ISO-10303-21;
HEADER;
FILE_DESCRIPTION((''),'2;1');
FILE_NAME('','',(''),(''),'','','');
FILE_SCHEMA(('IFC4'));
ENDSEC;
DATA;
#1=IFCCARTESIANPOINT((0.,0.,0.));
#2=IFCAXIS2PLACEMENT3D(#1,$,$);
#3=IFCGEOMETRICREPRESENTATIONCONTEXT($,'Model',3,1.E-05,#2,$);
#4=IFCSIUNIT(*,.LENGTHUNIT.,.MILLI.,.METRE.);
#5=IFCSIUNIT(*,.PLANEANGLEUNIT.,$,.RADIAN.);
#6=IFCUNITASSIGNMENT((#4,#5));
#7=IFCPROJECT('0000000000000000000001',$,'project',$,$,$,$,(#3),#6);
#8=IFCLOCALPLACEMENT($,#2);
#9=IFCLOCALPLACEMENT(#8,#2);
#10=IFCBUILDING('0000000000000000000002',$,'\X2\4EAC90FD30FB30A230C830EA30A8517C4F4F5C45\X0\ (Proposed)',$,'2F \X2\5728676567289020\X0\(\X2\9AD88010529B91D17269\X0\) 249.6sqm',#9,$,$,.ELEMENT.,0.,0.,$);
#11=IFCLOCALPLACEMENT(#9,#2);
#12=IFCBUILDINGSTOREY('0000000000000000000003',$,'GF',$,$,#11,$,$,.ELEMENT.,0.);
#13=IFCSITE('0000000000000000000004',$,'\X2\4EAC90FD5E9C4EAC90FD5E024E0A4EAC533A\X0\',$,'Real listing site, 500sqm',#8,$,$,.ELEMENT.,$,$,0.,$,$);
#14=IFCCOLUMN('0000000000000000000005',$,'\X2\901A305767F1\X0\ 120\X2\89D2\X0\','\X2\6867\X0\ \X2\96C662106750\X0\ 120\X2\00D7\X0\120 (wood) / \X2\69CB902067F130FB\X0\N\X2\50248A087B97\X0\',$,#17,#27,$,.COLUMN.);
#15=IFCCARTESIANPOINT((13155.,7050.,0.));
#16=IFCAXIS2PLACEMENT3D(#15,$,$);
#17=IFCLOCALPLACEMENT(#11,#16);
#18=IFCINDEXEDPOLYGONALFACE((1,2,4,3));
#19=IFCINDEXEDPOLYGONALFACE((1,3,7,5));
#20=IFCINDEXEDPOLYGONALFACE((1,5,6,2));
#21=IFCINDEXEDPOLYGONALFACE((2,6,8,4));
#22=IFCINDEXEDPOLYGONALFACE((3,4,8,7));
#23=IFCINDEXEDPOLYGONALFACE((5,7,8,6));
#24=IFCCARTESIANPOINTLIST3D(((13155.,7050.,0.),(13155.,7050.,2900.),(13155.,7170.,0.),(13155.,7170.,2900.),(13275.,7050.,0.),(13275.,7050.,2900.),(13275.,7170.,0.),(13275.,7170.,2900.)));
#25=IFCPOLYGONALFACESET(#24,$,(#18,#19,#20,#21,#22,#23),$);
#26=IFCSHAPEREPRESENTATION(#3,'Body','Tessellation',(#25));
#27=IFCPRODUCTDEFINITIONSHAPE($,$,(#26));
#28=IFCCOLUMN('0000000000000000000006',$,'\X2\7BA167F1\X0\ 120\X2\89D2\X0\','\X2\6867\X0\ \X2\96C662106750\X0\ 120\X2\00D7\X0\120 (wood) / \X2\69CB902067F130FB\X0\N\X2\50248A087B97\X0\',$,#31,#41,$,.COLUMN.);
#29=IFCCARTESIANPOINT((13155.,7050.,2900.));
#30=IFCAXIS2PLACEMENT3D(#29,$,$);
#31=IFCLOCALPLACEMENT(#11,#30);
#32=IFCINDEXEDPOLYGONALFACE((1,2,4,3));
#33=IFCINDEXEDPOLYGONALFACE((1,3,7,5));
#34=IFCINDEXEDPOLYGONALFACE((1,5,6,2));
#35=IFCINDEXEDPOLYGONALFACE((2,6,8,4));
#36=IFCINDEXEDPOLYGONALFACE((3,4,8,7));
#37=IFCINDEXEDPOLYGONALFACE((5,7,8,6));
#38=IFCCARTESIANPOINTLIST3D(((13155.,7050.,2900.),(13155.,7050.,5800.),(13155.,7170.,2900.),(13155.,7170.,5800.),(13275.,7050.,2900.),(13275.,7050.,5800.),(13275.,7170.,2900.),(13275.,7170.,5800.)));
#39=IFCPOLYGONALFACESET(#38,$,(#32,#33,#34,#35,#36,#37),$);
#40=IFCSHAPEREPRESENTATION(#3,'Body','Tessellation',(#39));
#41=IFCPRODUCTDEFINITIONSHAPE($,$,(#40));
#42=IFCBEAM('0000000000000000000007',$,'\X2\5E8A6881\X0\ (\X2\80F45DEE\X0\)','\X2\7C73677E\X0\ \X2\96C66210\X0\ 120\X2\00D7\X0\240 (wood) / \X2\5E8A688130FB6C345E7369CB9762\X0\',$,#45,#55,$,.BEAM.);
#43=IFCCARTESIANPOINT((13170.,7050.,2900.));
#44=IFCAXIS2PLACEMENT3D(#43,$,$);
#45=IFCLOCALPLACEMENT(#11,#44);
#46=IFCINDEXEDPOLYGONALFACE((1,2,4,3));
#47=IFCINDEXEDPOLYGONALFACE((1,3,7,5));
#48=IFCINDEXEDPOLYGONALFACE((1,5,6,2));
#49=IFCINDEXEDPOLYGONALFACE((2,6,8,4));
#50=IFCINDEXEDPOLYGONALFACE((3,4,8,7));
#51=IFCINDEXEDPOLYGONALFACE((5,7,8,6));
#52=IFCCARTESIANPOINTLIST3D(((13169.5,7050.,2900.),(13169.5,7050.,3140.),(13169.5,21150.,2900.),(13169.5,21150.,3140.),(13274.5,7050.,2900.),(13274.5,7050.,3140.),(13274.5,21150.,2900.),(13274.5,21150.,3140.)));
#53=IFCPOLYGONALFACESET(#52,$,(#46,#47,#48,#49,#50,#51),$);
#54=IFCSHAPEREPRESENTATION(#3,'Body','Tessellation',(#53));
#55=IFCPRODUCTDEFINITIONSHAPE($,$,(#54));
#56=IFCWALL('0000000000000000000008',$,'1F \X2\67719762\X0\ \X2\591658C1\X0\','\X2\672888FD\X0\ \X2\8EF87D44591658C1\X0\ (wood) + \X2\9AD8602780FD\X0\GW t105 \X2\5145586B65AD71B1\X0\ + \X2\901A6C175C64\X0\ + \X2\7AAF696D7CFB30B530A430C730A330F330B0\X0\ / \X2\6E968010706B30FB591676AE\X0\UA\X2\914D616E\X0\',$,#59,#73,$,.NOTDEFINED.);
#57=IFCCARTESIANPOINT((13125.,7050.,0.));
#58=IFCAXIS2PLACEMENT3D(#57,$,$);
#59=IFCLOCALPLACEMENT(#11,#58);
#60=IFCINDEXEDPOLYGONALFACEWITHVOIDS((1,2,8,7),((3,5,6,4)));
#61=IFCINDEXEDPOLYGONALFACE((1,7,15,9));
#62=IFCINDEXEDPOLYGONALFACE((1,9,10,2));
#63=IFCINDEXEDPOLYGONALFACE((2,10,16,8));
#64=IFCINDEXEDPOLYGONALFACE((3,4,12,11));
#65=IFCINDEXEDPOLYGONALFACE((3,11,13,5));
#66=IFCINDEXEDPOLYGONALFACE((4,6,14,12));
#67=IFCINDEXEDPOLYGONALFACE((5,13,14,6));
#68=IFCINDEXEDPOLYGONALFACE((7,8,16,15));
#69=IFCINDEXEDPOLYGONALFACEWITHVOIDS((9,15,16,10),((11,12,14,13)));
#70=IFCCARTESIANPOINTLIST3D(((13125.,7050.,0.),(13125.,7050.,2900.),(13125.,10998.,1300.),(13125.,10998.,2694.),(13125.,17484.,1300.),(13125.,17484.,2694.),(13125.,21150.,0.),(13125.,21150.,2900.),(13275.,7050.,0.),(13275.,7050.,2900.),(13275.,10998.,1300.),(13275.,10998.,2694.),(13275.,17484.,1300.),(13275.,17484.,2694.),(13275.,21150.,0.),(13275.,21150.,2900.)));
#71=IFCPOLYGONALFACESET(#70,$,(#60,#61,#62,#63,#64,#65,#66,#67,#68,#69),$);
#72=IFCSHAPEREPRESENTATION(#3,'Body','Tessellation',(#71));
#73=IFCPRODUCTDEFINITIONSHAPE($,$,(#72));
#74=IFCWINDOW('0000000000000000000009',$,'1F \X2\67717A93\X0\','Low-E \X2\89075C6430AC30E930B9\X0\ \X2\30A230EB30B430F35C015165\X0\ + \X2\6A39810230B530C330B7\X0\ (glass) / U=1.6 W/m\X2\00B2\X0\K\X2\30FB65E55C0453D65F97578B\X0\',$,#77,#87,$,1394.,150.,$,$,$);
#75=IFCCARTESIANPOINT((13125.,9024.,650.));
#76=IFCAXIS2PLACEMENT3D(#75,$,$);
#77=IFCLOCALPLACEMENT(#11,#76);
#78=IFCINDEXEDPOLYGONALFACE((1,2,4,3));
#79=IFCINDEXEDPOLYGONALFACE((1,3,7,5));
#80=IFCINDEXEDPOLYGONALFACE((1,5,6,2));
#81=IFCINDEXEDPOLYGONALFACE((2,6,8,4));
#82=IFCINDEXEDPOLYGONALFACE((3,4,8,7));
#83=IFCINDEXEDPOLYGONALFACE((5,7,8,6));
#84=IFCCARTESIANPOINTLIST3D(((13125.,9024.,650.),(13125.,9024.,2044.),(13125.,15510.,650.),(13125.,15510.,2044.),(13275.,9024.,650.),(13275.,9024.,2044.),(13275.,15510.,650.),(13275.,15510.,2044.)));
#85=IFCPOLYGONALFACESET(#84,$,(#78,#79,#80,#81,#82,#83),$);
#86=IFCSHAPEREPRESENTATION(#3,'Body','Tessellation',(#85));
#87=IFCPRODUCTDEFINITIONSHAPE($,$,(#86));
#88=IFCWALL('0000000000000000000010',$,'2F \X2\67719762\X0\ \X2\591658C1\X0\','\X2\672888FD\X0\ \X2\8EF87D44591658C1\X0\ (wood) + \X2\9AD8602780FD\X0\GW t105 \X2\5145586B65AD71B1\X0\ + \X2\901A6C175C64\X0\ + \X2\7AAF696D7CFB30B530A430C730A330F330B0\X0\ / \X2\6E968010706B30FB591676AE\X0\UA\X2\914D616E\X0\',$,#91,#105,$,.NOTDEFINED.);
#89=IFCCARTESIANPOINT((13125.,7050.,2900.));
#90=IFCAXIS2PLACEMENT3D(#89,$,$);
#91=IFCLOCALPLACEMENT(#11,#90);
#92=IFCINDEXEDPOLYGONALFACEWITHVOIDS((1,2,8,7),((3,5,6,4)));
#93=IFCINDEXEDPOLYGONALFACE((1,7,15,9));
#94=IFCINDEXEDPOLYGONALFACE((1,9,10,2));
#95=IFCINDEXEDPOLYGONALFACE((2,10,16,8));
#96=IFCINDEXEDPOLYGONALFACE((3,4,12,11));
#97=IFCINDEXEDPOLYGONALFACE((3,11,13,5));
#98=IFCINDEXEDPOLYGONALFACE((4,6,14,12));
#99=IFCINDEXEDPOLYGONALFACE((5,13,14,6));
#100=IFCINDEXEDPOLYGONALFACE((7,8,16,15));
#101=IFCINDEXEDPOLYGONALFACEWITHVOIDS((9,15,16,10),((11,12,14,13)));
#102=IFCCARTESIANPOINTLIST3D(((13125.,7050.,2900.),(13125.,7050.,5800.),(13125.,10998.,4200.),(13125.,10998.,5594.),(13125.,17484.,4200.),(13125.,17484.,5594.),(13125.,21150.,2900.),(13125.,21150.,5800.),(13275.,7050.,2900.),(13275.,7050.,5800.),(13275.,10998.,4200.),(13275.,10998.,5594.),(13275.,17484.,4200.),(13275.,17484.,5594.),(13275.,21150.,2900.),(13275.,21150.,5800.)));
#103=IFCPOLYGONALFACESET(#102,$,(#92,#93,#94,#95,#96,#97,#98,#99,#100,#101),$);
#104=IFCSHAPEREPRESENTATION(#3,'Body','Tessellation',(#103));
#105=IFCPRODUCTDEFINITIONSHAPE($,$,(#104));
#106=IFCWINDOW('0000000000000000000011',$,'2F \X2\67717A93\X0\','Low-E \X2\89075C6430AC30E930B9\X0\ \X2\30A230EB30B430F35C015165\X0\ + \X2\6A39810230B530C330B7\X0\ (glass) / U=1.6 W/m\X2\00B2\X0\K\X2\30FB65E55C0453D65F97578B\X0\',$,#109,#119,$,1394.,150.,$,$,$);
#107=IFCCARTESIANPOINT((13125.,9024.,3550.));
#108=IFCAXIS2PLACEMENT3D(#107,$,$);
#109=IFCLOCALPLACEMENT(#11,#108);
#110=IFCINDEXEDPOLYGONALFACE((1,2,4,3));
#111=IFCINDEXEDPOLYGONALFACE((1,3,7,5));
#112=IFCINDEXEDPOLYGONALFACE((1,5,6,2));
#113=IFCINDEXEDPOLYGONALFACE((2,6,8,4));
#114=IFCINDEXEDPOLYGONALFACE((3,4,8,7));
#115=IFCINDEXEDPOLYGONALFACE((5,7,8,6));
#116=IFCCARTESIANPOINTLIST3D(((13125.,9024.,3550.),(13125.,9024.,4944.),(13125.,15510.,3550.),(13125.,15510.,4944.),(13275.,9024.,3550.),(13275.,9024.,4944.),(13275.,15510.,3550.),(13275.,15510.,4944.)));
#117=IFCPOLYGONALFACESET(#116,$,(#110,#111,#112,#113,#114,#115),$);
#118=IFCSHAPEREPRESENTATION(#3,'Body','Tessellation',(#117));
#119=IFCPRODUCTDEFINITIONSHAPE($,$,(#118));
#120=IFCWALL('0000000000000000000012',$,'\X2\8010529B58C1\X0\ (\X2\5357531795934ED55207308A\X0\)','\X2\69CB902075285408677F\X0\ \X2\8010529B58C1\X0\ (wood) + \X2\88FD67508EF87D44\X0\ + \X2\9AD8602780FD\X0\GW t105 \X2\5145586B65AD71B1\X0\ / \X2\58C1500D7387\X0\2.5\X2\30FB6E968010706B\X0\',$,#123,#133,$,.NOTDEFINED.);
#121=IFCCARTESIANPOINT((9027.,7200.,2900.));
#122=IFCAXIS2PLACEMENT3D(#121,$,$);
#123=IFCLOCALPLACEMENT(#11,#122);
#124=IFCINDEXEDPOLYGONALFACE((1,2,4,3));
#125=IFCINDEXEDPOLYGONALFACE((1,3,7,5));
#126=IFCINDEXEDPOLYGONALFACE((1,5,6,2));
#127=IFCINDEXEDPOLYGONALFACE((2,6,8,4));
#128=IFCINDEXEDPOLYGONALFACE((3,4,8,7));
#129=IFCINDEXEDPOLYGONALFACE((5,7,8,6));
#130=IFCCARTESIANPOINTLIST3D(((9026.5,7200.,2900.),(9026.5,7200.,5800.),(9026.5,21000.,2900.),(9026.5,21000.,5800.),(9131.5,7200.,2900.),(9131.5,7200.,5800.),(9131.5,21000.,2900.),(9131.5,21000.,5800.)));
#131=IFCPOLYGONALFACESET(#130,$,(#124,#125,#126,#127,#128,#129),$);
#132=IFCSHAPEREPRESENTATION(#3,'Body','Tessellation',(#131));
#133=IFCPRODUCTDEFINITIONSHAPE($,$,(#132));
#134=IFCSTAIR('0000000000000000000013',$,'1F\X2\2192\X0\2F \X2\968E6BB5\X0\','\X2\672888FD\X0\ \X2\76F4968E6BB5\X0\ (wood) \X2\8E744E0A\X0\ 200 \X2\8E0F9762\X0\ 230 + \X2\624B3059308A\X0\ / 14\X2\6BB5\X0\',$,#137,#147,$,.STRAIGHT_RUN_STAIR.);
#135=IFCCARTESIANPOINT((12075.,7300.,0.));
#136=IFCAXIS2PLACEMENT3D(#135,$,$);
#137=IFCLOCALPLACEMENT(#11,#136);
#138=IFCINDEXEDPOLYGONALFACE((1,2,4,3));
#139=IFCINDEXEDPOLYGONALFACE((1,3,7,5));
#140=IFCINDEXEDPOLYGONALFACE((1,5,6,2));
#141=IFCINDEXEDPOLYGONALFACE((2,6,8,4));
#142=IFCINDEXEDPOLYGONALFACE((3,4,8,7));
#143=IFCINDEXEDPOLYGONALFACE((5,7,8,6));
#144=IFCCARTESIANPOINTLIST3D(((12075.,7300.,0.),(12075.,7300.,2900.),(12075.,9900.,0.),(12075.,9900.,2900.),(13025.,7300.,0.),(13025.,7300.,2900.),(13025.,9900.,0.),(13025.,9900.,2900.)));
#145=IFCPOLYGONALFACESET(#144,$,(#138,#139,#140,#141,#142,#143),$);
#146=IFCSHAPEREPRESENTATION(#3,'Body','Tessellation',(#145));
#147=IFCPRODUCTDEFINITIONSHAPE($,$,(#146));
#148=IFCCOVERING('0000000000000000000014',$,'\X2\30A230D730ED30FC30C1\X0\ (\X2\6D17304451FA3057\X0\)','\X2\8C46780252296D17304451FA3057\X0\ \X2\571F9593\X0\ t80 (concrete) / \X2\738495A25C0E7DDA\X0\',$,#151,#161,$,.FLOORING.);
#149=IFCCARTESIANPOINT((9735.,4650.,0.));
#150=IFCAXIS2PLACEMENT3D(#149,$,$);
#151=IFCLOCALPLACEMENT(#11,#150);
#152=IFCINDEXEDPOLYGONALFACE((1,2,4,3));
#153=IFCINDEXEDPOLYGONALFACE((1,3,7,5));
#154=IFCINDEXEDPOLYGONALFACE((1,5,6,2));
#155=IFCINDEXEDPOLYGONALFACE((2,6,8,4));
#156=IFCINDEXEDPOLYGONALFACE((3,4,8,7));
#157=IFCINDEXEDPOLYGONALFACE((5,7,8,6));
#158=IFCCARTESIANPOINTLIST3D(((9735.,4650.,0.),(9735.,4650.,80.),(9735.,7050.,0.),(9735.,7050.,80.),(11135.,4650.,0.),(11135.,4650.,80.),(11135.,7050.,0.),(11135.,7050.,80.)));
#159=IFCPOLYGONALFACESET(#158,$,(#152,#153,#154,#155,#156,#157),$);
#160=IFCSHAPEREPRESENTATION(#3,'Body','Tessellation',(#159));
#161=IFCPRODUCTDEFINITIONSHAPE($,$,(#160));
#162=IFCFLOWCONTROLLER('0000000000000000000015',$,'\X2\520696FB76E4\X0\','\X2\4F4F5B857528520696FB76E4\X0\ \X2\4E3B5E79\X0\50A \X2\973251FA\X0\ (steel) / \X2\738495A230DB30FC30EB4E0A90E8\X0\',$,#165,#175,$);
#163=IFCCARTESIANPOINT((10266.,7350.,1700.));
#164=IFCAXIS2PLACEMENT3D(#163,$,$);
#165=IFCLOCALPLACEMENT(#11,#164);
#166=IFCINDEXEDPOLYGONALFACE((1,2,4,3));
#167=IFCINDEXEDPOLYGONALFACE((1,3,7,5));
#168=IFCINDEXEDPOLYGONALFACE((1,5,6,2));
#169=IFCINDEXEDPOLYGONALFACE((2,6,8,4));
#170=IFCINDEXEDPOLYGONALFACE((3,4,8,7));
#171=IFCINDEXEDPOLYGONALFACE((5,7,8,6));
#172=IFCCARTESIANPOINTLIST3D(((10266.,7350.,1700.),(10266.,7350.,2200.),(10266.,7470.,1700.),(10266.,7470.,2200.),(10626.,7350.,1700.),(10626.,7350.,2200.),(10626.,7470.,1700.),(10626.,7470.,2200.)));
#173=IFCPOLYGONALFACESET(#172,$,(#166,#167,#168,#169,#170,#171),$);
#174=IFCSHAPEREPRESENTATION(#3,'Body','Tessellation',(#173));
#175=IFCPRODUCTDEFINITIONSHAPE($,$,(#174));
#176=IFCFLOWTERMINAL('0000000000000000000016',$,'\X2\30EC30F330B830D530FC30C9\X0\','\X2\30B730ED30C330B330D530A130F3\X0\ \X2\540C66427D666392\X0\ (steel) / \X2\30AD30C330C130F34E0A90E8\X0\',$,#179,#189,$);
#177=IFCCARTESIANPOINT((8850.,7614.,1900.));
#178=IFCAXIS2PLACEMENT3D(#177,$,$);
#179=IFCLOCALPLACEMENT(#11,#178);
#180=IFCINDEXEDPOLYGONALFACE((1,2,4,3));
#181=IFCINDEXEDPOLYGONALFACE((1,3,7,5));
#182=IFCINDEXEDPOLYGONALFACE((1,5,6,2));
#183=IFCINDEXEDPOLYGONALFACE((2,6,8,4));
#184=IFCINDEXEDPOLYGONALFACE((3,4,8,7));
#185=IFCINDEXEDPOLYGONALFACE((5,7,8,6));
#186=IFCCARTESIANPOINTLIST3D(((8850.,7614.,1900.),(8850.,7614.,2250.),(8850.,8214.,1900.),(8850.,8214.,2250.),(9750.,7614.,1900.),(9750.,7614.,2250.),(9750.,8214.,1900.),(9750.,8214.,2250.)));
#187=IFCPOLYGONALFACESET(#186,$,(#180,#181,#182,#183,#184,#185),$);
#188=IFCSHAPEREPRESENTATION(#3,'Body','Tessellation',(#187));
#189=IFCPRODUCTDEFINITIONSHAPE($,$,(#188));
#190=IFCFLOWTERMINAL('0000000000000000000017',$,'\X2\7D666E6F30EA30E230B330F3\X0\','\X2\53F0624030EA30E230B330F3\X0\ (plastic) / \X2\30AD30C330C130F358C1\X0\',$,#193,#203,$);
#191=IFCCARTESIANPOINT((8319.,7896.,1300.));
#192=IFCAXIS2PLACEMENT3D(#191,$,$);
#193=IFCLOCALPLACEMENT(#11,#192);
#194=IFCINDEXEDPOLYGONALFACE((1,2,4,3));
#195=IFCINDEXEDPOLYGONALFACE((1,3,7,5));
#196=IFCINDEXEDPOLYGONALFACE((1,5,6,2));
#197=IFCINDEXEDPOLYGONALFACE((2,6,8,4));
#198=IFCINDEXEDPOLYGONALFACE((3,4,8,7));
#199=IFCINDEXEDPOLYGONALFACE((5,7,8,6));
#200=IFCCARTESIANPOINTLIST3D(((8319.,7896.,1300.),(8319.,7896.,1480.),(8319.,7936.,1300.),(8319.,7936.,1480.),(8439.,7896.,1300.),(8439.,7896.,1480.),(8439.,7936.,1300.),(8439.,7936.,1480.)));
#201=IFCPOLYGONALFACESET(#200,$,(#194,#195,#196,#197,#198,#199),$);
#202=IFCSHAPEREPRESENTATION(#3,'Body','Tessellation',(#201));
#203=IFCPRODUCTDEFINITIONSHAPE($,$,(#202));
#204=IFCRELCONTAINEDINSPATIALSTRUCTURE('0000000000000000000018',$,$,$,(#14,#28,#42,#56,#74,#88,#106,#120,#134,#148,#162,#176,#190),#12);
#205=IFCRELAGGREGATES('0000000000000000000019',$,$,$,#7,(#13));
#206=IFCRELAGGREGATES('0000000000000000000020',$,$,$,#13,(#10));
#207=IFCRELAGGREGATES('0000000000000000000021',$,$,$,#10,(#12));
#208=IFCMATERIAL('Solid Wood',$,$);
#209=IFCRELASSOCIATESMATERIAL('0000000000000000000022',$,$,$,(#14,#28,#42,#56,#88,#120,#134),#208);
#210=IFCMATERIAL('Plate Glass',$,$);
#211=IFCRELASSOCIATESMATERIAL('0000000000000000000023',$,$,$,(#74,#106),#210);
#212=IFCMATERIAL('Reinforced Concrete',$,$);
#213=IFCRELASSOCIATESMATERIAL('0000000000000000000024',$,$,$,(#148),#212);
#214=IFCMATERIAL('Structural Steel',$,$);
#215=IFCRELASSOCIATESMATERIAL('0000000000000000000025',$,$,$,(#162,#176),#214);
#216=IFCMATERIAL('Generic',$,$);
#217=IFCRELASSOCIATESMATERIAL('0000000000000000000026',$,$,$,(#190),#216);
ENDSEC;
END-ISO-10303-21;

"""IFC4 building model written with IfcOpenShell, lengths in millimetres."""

from ifc_helpers import new_model, si_unit, frame, frame_2d, origin, place, context, project, spatial, rectangle, extrude, material, element, fill, save


model = new_model("IFC4")

# Units and contexts
model_context = context("Model", 3, precision=1e-05, world=origin())
ifc_project = project(units=[si_unit("LENGTHUNIT", "METRE", prefix="MILLI"), si_unit("PLANEANGLEUNIT", "RADIAN")], contexts=[model_context])

# Site, building, storey
site_placement = place(None, origin())
site = spatial("IfcSite", under=ifc_project, at=site_placement, Name="京都府京都市上京区", ObjectType="Real listing site, 500sqm", CompositionType="ELEMENT", RefElevation=0.0)
building_placement = place(site_placement, origin())
building = spatial("IfcBuilding", under=site, at=building_placement, Name="京都・アトリエ兼住居 (Proposed)", ObjectType="2F 在来木造(高耐力金物) 249.6sqm", CompositionType="ELEMENT", ElevationOfRefHeight=0.0, ElevationOfTerrain=0.0)
storey_placement = place(building_placement, origin())
storey = spatial("IfcBuildingStorey", under=building, at=storey_placement, Name="GF", CompositionType="ELEMENT", Elevation=0.0)

# Columns
ifc_material_1 = material(Name="Solid Wood")
column_1_placement = place(storey_placement, frame((13155.0, 7050.0, 0.0)))
element("IfcColumn", 1, at=column_1_placement, inside=storey, material=ifc_material_1, Name="通し柱 120角", Description="桧 集成材 120×120 (wood) / 構造柱・N値計算", PredefinedType="COLUMN", context=model_context, shape_type="SweptSolid", body=[
    extrude(rectangle(XDim=120.0, YDim=120.0, at=frame_2d((60.0, 60.0))), frame((13155.0, 7050.0, 0.0)), (0.0, 0.0, 1.0), 2900.0),
])
column_2_placement = place(storey_placement, frame((13155.0, 7050.0, 2900.0)))
element("IfcColumn", 2, at=column_2_placement, inside=storey, material=ifc_material_1, Name="管柱 120角", Description="桧 集成材 120×120 (wood) / 構造柱・N値計算", PredefinedType="COLUMN", context=model_context, shape_type="SweptSolid", body=[
    extrude(rectangle(XDim=120.0, YDim=120.0, at=frame_2d((60.0, 60.0))), frame((13155.0, 7050.0, 2900.0)), (0.0, 0.0, 1.0), 2900.0),
])

# Beam
beam_1_placement = place(storey_placement, frame((13170.0, 7050.0, 2900.0)))
element("IfcBeam", 3, at=beam_1_placement, inside=storey, material=ifc_material_1, Name="床梁 (胴差)", Description="米松 集成 120×240 (wood) / 床梁・水平構面", PredefinedType="BEAM", context=model_context, shape_type="SweptSolid", body=[
    extrude(rectangle(XDim=105.0, YDim=14100.0, at=frame_2d((52.0, 7050.0))), frame((13170.0, 7050.0, 2900.0)), (0.0, 0.0, 1.0), 240.0),
])

# Wall, opening, window
wall_1_placement = place(storey_placement, frame((13125.0, 7050.0, 0.0)))
wall_1 = element("IfcWall", 4, at=wall_1_placement, inside=storey, material=ifc_material_1, Name="1F 東面 外壁", Description="木製 軸組外壁 (wood) + 高性能GW t105 充填断熱 + 通気層 + 窯業系サイディング / 準耐火・外皮UA配慮", PredefinedType="NOTDEFINED", context=model_context, shape_type="SweptSolid", body=[
    extrude(rectangle(XDim=150.0, YDim=14100.0, at=frame_2d((75.0, 7050.0))), frame((13125.0, 7050.0, 0.0)), (0.0, 0.0, 1.0), 2900.0),
])
opening_1_placement = place(storey_placement, frame((13125.0, 9024.0, 650.0)))
opening_1 = element("IfcOpeningElement", 5, at=opening_1_placement, cuts=wall_1, PredefinedType="NOTDEFINED", context=model_context, shape_type="SweptSolid", body=[
    extrude(rectangle(XDim=150.0, YDim=6486.0, at=frame_2d((75.0, 3243.0))), frame((13125.0, 9024.0, 650.0)), (0.0, 0.0, 1.0), 1394.0),
])
ifc_material_2 = material(Name="Plate Glass")
window_1_placement = place(storey_placement, frame((13125.0, 9024.0, 650.0)))
window_1 = element("IfcWindow", 6, at=window_1_placement, inside=storey, material=ifc_material_2, Name="1F 東窓", Description="Low-E 複層ガラス アルゴン封入 + 樹脂サッシ (glass) / U=1.6 W/m²K・日射取得型", OverallHeight=1394.0, OverallWidth=150.0, context=model_context, shape_type="SweptSolid", body=[
    extrude(rectangle(XDim=150.0, YDim=6486.0, at=frame_2d((75.0, 3243.0))), frame((13125.0, 9024.0, 650.0)), (0.0, 0.0, 1.0), 1394.0),
])
fill(opening_1, window_1)

# Wall, opening, window
wall_2_placement = place(storey_placement, frame((13125.0, 7050.0, 2900.0)))
wall_2 = element("IfcWall", 7, at=wall_2_placement, inside=storey, material=ifc_material_1, Name="2F 東面 外壁", Description="木製 軸組外壁 (wood) + 高性能GW t105 充填断熱 + 通気層 + 窯業系サイディング / 準耐火・外皮UA配慮", PredefinedType="NOTDEFINED", context=model_context, shape_type="SweptSolid", body=[
    extrude(rectangle(XDim=150.0, YDim=14100.0, at=frame_2d((75.0, 7050.0))), frame((13125.0, 7050.0, 2900.0)), (0.0, 0.0, 1.0), 2900.0),
])
opening_2_placement = place(storey_placement, frame((13125.0, 9024.0, 3550.0)))
opening_2 = element("IfcOpeningElement", 8, at=opening_2_placement, cuts=wall_2, PredefinedType="NOTDEFINED", context=model_context, shape_type="SweptSolid", body=[
    extrude(rectangle(XDim=150.0, YDim=6486.0, at=frame_2d((75.0, 3243.0))), frame((13125.0, 9024.0, 3550.0)), (0.0, 0.0, 1.0), 1394.0),
])
window_2_placement = place(storey_placement, frame((13125.0, 9024.0, 3550.0)))
window_2 = element("IfcWindow", 9, at=window_2_placement, inside=storey, material=ifc_material_2, Name="2F 東窓", Description="Low-E 複層ガラス アルゴン封入 + 樹脂サッシ (glass) / U=1.6 W/m²K・日射取得型", OverallHeight=1394.0, OverallWidth=150.0, context=model_context, shape_type="SweptSolid", body=[
    extrude(rectangle(XDim=150.0, YDim=6486.0, at=frame_2d((75.0, 3243.0))), frame((13125.0, 9024.0, 3550.0)), (0.0, 0.0, 1.0), 1394.0),
])
fill(opening_2, window_2)

# Wall
wall_3_placement = place(storey_placement, frame((9027.0, 7200.0, 2900.0)))
element("IfcWall", 10, at=wall_3_placement, inside=storey, material=ifc_material_1, Name="耐力壁 (南北間仕切り)", Description="構造用合板 耐力壁 (wood) + 製材軸組 + 高性能GW t105 充填断熱 / 壁倍率2.5・準耐火", PredefinedType="NOTDEFINED", context=model_context, shape_type="SweptSolid", body=[
    extrude(rectangle(XDim=105.0, YDim=13800.0, at=frame_2d((52.0, 6900.0))), frame((9027.0, 7200.0, 2900.0)), (0.0, 0.0, 1.0), 2900.0),
])

# Stair
stair_placement = place(storey_placement, frame((12075.0, 7300.0, 0.0)))
element("IfcStair", 11, at=stair_placement, inside=storey, material=ifc_material_1, Name="1F→2F 階段", Description="木製 直階段 (wood) 蹴上 200 踏面 230 + 手すり / 14段", PredefinedType="STRAIGHT_RUN_STAIR", context=model_context, shape_type="SweptSolid", body=[
    extrude(rectangle(XDim=950.0, YDim=2600.0, at=frame_2d((475.0, 1300.0))), frame((12075.0, 7300.0, 0.0)), (0.0, 0.0, 1.0), 2900.0),
])

# Covering
ifc_material_3 = material(Name="Reinforced Concrete")
covering_placement = place(storey_placement, frame((9735.0, 4650.0, 0.0)))
element("IfcCovering", 12, at=covering_placement, inside=storey, material=ifc_material_3, Name="アプローチ (洗い出し)", Description="豆砂利洗い出し 土間 t80 (concrete) / 玄関導線", PredefinedType="FLOORING", context=model_context, shape_type="SweptSolid", body=[
    extrude(rectangle(XDim=1400.0, YDim=2400.0, at=frame_2d((700.0, 1200.0))), frame((9735.0, 4650.0, 0.0)), (0.0, 0.0, 1.0), 80.0),
])

# Flow controller
ifc_material_4 = material(Name="Structural Steel")
flow_controller_placement = place(storey_placement, frame((10266.0, 7350.0, 1700.0)))
element("IfcFlowController", 13, at=flow_controller_placement, inside=storey, material=ifc_material_4, Name="分電盤", Description="住宅用分電盤 主幹50A 露出 (steel) / 玄関ホール上部", context=model_context, shape_type="SweptSolid", body=[
    extrude(rectangle(XDim=360.0, YDim=120.0, at=frame_2d((180.0, 60.0))), frame((10266.0, 7350.0, 1700.0)), (0.0, 0.0, 1.0), 500.0),
])

# Flow terminals
flow_terminal_1_placement = place(storey_placement, frame((8850.0, 7614.0, 1900.0)))
element("IfcFlowTerminal", 14, at=flow_terminal_1_placement, inside=storey, material=ifc_material_4, Name="レンジフード", Description="シロッコファン 同時給排 (steel) / キッチン上部", context=model_context, shape_type="SweptSolid", body=[
    extrude(rectangle(XDim=900.0, YDim=600.0, at=frame_2d((450.0, 300.0))), frame((8850.0, 7614.0, 1900.0)), (0.0, 0.0, 1.0), 350.0),
])
ifc_material_5 = material(Name="Generic")
flow_terminal_2_placement = place(storey_placement, frame((8319.0, 7896.0, 1300.0)))
element("IfcFlowTerminal", 15, at=flow_terminal_2_placement, inside=storey, material=ifc_material_5, Name="給湯リモコン", Description="台所リモコン (plastic) / キッチン壁", context=model_context, shape_type="SweptSolid", body=[
    extrude(rectangle(XDim=120.0, YDim=40.0, at=frame_2d((60.0, 20.0))), frame((8319.0, 7896.0, 1300.0)), (0.0, 0.0, 1.0), 180.0),
])

save(model, "model.ifc")
